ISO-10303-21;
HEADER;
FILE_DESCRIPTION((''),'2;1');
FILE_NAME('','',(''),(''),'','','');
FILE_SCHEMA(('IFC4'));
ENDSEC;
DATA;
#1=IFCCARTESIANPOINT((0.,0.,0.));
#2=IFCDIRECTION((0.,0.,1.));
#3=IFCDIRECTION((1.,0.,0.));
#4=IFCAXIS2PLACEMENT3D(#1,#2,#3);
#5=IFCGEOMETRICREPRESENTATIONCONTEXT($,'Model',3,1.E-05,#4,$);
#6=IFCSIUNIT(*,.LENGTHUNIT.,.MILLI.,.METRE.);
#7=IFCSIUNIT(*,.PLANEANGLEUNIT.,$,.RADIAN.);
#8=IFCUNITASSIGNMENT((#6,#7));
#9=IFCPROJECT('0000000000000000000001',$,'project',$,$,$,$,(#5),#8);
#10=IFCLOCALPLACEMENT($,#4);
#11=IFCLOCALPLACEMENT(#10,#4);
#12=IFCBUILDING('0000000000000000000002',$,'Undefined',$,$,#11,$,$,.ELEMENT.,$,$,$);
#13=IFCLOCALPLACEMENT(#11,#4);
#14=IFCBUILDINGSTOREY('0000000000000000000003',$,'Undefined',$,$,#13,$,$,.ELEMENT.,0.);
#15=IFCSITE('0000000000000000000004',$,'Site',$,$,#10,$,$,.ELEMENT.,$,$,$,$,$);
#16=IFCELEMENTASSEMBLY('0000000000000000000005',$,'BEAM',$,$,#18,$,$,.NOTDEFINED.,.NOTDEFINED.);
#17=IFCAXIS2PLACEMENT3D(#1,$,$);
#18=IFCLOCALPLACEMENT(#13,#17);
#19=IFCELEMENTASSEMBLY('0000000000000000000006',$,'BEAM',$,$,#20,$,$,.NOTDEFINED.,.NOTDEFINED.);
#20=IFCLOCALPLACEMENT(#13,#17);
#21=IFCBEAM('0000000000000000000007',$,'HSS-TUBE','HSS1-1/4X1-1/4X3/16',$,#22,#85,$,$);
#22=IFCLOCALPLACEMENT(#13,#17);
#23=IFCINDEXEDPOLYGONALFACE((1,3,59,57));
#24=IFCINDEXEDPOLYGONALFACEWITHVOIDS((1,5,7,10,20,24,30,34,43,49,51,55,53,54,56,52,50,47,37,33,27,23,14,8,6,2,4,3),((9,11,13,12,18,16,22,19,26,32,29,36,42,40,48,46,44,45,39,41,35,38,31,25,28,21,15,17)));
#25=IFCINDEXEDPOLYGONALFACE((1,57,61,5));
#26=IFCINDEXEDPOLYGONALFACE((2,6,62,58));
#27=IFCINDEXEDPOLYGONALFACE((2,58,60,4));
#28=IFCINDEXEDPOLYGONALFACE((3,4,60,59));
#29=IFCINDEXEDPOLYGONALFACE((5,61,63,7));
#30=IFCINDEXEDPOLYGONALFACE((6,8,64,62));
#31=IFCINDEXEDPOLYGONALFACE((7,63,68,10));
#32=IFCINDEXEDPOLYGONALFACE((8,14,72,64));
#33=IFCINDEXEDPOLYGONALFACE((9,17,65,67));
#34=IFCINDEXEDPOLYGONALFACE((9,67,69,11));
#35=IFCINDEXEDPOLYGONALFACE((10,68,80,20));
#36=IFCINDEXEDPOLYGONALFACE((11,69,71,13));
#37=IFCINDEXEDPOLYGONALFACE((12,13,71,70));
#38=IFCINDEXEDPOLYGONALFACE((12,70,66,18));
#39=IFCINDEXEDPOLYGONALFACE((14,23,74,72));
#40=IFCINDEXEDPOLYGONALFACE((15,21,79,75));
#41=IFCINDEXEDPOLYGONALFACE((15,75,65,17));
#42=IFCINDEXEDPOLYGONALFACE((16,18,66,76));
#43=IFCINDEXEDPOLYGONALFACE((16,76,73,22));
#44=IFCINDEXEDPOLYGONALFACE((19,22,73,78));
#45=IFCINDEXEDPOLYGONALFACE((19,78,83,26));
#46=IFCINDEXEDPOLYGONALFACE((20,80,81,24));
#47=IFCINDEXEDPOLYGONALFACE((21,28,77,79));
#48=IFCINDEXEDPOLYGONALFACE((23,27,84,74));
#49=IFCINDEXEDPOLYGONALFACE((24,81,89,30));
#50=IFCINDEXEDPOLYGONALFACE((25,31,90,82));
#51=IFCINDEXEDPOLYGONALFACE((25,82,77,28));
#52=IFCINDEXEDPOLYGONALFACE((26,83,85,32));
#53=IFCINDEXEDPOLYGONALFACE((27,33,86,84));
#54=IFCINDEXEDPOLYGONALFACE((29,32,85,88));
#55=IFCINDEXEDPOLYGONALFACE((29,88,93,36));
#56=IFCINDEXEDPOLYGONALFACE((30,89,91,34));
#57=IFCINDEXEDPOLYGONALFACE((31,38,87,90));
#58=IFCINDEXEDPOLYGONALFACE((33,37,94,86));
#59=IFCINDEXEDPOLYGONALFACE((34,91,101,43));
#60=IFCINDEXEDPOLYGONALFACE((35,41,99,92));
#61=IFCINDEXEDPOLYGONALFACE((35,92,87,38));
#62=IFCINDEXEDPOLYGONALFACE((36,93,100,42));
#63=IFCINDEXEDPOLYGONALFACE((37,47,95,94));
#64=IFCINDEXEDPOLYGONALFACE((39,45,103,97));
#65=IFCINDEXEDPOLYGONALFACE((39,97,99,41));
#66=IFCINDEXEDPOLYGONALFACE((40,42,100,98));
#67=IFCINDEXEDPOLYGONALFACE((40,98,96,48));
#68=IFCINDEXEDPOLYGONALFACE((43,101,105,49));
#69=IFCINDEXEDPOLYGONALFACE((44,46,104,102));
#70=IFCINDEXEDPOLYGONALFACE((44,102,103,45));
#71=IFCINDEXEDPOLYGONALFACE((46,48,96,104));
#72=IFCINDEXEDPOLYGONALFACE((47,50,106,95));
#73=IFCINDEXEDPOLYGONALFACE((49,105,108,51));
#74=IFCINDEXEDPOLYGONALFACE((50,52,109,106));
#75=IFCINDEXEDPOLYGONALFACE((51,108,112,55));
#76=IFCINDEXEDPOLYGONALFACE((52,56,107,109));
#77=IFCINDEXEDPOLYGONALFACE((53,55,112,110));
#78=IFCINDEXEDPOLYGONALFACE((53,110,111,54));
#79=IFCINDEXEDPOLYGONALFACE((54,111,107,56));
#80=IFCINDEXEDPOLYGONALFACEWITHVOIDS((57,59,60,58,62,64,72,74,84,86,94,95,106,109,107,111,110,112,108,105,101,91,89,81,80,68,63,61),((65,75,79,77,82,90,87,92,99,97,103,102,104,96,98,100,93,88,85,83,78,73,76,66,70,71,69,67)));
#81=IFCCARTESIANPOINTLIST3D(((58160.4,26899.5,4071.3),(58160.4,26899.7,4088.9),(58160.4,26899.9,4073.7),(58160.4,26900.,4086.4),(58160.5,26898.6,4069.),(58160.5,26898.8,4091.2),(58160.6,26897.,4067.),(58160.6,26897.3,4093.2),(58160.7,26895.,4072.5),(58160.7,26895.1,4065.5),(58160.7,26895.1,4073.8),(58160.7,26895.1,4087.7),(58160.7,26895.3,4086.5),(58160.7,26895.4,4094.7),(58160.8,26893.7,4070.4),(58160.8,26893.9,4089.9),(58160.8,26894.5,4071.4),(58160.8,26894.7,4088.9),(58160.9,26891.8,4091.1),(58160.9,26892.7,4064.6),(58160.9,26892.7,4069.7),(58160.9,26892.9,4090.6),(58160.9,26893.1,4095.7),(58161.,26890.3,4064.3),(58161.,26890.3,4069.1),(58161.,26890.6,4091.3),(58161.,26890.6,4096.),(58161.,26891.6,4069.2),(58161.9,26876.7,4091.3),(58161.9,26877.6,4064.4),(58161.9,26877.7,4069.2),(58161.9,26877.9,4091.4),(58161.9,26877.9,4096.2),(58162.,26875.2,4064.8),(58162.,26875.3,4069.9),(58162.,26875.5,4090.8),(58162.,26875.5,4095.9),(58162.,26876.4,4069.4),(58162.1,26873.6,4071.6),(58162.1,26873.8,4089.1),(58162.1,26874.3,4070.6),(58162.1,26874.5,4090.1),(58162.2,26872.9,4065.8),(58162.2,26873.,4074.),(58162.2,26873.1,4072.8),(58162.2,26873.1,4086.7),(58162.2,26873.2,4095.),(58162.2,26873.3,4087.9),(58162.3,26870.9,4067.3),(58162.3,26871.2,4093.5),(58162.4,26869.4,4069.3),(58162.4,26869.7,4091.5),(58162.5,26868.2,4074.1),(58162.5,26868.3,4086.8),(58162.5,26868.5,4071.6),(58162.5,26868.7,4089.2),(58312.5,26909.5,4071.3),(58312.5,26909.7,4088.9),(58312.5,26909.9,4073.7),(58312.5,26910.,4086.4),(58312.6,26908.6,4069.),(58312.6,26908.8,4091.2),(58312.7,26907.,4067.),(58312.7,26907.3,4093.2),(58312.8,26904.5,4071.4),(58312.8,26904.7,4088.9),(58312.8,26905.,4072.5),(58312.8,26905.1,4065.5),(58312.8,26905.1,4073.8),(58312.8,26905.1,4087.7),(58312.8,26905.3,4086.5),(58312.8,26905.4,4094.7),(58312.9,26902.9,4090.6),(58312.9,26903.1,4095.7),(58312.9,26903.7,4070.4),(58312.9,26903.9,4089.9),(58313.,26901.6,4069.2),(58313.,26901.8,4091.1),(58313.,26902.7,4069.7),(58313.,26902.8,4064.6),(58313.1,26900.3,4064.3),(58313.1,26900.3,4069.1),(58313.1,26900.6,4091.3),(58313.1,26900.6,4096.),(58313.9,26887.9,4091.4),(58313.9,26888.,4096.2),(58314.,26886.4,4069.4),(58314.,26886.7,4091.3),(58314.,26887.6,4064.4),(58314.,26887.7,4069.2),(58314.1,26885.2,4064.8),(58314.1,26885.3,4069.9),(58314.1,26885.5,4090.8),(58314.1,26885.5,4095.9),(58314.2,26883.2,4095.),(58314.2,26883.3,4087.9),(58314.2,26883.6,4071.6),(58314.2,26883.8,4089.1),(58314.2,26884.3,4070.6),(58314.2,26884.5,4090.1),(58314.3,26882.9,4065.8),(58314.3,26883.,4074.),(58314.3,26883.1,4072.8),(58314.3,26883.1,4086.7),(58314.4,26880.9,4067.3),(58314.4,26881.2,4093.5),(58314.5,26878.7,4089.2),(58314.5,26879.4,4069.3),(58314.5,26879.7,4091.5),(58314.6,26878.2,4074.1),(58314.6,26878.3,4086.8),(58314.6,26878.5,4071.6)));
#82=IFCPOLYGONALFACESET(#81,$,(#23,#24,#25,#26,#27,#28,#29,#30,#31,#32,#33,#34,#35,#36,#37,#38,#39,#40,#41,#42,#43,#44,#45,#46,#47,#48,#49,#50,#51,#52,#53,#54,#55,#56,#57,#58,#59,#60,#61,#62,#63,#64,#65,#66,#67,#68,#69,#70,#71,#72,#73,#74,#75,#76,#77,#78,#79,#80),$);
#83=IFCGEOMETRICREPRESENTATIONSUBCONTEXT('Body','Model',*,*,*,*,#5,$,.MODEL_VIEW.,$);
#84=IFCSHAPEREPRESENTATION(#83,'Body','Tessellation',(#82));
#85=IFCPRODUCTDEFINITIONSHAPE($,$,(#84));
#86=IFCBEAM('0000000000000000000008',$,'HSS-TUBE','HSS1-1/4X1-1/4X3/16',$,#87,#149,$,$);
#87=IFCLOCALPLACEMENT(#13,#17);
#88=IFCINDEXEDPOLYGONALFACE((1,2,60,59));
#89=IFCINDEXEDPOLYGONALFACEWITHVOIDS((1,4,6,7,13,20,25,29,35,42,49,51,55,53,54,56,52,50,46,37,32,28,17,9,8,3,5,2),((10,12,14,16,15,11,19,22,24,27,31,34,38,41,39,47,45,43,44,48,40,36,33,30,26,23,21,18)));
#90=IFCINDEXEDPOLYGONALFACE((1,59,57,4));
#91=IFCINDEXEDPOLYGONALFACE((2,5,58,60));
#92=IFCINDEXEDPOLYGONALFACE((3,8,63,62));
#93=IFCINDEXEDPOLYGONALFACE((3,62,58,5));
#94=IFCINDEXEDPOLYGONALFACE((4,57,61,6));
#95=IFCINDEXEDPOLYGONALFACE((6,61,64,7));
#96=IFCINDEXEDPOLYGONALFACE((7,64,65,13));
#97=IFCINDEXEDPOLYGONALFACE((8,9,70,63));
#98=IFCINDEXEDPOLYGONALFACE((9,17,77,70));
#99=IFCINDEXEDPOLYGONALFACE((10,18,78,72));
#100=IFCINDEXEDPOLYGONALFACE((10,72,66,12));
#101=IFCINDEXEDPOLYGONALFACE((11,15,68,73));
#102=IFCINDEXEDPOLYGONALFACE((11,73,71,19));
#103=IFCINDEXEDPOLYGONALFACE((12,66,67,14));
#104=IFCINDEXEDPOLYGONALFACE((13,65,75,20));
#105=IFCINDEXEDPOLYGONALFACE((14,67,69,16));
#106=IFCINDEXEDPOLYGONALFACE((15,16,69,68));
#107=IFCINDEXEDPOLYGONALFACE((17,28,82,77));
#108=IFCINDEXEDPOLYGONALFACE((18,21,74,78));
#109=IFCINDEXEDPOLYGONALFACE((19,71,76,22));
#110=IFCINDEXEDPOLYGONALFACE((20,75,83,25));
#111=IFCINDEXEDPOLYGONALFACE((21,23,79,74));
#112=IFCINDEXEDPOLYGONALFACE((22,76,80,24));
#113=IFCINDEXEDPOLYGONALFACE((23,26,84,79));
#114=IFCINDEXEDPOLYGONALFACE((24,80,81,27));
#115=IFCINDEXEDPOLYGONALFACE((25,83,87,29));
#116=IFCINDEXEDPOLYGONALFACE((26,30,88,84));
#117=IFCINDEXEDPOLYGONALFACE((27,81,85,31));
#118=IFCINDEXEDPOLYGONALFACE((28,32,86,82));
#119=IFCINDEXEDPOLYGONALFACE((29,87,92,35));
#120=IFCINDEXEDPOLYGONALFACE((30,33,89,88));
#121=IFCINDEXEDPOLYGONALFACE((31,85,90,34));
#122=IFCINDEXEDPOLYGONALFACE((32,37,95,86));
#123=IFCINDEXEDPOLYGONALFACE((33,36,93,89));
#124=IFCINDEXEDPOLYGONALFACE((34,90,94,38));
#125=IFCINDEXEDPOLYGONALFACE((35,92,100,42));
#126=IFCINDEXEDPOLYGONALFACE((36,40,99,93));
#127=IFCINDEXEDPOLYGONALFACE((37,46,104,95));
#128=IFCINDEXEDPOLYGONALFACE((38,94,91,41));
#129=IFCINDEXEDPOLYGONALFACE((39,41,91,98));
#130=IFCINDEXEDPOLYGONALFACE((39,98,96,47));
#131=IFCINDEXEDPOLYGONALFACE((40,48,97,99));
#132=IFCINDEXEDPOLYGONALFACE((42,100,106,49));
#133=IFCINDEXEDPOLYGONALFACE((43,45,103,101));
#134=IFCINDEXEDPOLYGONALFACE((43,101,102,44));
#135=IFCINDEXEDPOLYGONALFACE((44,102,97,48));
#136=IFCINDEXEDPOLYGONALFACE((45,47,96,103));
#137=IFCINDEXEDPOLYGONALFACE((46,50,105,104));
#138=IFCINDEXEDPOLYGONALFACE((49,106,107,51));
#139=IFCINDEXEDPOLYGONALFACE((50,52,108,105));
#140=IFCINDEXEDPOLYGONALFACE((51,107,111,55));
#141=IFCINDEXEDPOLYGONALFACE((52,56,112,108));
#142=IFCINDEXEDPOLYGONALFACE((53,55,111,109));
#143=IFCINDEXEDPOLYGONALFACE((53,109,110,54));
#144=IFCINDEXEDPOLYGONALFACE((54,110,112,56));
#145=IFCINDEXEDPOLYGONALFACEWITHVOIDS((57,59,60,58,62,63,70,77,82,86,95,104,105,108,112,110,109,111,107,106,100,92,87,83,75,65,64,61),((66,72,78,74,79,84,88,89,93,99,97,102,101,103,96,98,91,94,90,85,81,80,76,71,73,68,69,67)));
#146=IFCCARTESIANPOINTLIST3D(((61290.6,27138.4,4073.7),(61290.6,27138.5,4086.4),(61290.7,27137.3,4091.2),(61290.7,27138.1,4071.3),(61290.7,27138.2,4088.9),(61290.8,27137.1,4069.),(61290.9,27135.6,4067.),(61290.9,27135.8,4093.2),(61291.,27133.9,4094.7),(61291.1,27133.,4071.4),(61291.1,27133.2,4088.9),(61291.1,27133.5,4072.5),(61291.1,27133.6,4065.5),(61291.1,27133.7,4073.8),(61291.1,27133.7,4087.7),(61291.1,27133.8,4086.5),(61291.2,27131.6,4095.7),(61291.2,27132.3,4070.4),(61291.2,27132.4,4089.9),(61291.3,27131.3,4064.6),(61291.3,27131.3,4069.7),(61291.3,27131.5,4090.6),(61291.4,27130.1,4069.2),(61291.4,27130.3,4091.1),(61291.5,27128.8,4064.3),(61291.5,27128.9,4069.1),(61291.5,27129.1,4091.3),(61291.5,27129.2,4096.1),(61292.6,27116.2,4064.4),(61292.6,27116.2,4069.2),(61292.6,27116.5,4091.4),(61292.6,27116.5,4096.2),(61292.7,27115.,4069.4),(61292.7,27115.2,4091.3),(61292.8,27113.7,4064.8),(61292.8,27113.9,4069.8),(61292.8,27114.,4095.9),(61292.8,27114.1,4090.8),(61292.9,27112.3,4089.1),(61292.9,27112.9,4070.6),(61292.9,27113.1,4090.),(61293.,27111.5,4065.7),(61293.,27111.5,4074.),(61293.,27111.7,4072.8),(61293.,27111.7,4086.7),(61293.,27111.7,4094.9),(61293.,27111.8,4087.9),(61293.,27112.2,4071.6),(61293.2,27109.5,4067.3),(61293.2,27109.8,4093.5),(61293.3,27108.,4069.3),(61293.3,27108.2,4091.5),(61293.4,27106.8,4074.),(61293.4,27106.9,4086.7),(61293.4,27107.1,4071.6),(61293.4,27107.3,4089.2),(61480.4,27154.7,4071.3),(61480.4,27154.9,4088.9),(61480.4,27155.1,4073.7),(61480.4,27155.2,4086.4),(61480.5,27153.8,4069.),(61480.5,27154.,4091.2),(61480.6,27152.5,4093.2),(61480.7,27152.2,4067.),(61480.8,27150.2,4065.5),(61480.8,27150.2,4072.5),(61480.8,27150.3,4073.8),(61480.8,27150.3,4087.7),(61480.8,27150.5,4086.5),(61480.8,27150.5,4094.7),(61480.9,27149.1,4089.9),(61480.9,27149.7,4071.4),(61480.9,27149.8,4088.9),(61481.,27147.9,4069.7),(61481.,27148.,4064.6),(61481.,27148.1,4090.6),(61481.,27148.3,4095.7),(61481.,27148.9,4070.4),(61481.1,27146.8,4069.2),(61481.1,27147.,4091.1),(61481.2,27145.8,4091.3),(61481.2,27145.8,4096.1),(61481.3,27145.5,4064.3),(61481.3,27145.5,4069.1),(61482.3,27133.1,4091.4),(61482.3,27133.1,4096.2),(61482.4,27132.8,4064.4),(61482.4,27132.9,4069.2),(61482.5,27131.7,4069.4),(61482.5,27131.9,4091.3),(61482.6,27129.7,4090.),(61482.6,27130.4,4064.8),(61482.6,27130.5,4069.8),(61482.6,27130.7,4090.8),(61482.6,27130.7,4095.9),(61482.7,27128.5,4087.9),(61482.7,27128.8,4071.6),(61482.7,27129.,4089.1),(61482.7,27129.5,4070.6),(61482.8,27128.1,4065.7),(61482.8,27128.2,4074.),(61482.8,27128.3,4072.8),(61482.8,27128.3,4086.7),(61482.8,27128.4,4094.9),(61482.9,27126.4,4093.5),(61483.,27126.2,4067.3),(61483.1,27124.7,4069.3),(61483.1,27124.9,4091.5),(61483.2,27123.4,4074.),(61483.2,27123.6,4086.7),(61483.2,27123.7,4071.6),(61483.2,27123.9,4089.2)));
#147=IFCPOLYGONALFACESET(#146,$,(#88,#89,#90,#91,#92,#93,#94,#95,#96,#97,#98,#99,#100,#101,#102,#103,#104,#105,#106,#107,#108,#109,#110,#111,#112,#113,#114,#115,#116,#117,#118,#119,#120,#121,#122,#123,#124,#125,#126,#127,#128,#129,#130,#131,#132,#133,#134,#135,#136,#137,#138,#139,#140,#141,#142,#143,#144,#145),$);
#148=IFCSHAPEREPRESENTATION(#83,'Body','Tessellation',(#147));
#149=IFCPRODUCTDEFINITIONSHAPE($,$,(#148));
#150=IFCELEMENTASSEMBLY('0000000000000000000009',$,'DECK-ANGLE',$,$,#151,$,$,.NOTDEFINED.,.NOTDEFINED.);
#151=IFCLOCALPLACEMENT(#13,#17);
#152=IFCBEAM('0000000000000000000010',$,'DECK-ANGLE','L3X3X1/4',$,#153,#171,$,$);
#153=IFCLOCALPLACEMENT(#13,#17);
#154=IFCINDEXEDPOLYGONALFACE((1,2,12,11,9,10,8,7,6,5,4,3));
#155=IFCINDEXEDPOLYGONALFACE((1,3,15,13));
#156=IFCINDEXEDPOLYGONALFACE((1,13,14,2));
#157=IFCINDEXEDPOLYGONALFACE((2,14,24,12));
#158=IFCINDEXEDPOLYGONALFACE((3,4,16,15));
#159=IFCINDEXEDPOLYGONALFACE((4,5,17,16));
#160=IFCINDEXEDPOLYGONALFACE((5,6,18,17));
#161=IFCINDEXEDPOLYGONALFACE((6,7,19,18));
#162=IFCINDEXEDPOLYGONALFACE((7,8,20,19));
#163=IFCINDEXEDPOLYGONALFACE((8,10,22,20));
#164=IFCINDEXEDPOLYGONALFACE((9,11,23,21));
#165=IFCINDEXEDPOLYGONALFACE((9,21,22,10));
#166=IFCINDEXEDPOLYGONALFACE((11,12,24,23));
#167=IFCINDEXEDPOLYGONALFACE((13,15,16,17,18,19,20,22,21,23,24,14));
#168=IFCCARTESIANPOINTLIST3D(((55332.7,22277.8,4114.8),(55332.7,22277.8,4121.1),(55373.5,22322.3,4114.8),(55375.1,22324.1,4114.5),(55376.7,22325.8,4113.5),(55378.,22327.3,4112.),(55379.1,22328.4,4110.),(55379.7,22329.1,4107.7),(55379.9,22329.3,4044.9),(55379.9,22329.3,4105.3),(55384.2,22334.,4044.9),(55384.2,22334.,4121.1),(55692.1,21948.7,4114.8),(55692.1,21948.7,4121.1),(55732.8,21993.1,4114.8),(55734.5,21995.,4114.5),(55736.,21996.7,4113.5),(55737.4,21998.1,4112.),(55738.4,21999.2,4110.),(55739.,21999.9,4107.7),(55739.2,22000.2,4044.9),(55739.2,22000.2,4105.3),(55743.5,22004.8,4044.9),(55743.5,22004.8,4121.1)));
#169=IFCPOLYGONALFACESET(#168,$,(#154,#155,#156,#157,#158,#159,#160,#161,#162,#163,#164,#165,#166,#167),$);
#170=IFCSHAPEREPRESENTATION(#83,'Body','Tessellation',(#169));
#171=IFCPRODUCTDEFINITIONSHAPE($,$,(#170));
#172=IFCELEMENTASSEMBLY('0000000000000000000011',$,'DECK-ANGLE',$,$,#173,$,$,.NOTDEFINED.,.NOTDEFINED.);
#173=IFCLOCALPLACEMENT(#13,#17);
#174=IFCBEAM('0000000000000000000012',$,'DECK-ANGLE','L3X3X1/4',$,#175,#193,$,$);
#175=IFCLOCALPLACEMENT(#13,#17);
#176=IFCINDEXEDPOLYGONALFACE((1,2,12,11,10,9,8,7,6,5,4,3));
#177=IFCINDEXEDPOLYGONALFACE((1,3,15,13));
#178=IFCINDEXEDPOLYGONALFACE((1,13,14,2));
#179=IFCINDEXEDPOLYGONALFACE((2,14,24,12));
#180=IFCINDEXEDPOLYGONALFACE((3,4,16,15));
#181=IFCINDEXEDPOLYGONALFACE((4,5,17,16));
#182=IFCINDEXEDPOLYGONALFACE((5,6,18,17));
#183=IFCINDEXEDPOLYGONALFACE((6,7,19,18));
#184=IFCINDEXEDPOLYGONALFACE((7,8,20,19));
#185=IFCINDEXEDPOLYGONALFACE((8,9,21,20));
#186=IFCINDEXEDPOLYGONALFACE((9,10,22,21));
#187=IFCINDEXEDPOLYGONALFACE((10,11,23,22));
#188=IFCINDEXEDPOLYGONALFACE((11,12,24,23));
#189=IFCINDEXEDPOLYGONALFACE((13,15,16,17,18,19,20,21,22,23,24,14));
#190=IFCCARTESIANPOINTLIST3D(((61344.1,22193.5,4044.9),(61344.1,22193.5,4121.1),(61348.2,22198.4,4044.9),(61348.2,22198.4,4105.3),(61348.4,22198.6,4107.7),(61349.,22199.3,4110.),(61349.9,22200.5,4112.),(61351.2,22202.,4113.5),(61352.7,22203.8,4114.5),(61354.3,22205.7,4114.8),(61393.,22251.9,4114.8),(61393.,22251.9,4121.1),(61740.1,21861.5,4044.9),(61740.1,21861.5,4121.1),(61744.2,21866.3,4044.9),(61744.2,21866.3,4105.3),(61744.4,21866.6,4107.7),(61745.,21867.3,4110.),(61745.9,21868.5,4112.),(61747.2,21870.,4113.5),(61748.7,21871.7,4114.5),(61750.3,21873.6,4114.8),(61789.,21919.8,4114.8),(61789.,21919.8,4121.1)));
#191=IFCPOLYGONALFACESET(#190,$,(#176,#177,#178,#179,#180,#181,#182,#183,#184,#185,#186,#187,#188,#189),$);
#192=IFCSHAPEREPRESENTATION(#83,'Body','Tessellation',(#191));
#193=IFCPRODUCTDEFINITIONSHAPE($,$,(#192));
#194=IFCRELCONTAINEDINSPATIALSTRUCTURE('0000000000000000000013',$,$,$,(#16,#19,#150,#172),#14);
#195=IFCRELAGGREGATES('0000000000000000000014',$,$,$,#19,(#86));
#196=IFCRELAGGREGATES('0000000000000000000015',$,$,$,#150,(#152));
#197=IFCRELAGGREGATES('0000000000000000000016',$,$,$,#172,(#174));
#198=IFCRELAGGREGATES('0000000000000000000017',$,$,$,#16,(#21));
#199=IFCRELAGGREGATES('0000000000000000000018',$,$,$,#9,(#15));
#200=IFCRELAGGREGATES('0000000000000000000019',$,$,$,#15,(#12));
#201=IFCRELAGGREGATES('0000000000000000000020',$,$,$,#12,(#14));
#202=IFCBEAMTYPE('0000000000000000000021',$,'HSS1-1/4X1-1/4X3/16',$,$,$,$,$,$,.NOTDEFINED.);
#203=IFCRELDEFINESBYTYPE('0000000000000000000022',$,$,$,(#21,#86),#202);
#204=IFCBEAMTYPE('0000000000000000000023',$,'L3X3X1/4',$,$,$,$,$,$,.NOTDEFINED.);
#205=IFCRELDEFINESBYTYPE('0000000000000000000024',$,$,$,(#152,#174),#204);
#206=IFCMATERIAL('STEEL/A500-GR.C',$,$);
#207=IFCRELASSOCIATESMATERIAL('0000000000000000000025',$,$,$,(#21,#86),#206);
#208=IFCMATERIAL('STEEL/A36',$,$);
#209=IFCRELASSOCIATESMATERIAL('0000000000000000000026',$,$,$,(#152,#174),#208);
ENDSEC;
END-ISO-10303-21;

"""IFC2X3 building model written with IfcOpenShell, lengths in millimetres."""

from ifc_helpers import new_model, si_unit, frame, origin_with_axes, origin_2d_with_axis, place, context, subcontext, project, spatial, hollow_rectangle, l_section, extrude, material, type_object, element, aggregate, save


model = new_model("IFC2X3")

# Units and contexts
model_context = context("Model", 3, precision=1e-05, world=origin_with_axes())
body_context = subcontext(model_context, "Body", "Model", "MODEL_VIEW")
ifc_project = project(units=[si_unit("LENGTHUNIT", "METRE", prefix="MILLI"), si_unit("PLANEANGLEUNIT", "RADIAN")], contexts=[model_context])

# Site, building, storey
site_placement = place(None, origin_with_axes())
site = spatial("IfcSite", under=ifc_project, at=site_placement, Name="Site", CompositionType="ELEMENT")
building_placement = place(site_placement, origin_with_axes())
building = spatial("IfcBuilding", under=site, at=building_placement, Name="Undefined", CompositionType="ELEMENT")
storey_placement = place(building_placement, origin_with_axes())
storey = spatial("IfcBuildingStorey", under=building, at=storey_placement, Name="Undefined", CompositionType="ELEMENT", Elevation=0.0)

# Element assemblies
assembly_1_placement = place(storey_placement, origin_with_axes())
assembly_1 = element("IfcElementAssembly", 1, at=assembly_1_placement, inside=storey, Name="BEAM", AssemblyPlace="NOTDEFINED", PredefinedType="NOTDEFINED")
assembly_2_placement = place(storey_placement, origin_with_axes())
assembly_2 = element("IfcElementAssembly", 2, at=assembly_2_placement, inside=storey, Name="BEAM", AssemblyPlace="NOTDEFINED", PredefinedType="NOTDEFINED")

# Beams
ifc_material_1 = material(Name="STEEL/A500-GR.C")
beam_type_1 = type_object("IfcBeamType", Name="HSS1-1/4X1-1/4X3/16", PredefinedType="NOTDEFINED")
beam_1_placement = place(assembly_1_placement, frame((58161.5, 26884.1, 4080.2), z_axis=(-0.00069, 0.010495, 0.999945), x_axis=(0.997843, 0.065644, 0.0)))
beam_1 = element("IfcBeam", 3, at=beam_1_placement, type_object=beam_type_1, material=ifc_material_1, Name="HSS-TUBE", Description="HSS1-1/4X1-1/4X3/16", context=body_context, shape_type="SweptSolid", body=[
    extrude(hollow_rectangle(XDim=31.8, YDim=31.8, WallThickness=4.8, InnerFilletRadius=4.8, OuterFilletRadius=9.5, at=origin_2d_with_axis()), frame((152.4, 0.0, 0.0), z_axis=(-1.0, 0.0, 0.0), x_axis=(0.0, -1.0, 0.0)), (0.0, 0.0, 1.0), 152.4),
])
beam_2_placement = place(assembly_2_placement, frame((61292.0, 27122.7, 4080.2), z_axis=(-0.000852, 0.009709, 0.999953), x_axis=(0.996174, 0.087396, 0.0)))
beam_2 = element("IfcBeam", 4, at=beam_2_placement, type_object=beam_type_1, material=ifc_material_1, Name="HSS-TUBE", Description="HSS1-1/4X1-1/4X3/16", context=body_context, shape_type="SweptSolid", body=[
    extrude(hollow_rectangle(XDim=31.8, YDim=31.8, WallThickness=4.8, InnerFilletRadius=4.8, OuterFilletRadius=9.5, at=origin_2d_with_axis()), frame((190.5, 0.0, 0.0), z_axis=(-1.0, 0.0, 0.0), x_axis=(0.0, -1.0, 0.0)), (0.0, 0.0, 1.0), 190.5),
])
aggregate(assembly_2, [beam_2])

# Element assemblies, beams
assembly_3_placement = place(storey_placement, origin_with_axes())
assembly_3 = element("IfcElementAssembly", 5, at=assembly_3_placement, inside=storey, Name="DECK-ANGLE", AssemblyPlace="NOTDEFINED", PredefinedType="NOTDEFINED")
ifc_material_2 = material(Name="STEEL/A36")
beam_type_2 = type_object("IfcBeamType", Name="L3X3X1/4", PredefinedType="NOTDEFINED")
beam_3_placement = place(assembly_3_placement, frame((55717.8, 21976.8, 4083.0), z_axis=(0.0, 0.0, -1.0), x_axis=(-0.737395, 0.675462, 0.0)))
beam_3 = element("IfcBeam", 6, at=beam_3_placement, type_object=beam_type_2, material=ifc_material_2, Name="DECK-ANGLE", Description="L3X3X1/4", context=body_context, shape_type="SweptSolid", body=[
    extrude(l_section(Depth=76.2, Width=76.2, Thickness=6.3, FilletRadius=9.5, at=origin_2d_with_axis()), frame((487.3, 0.0, 0.0), z_axis=(-1.0, 0.0, 0.0), x_axis=(0.0, -1.0, 0.0)), (0.0, 0.0, 1.0), 487.3),
])
aggregate(assembly_3, [beam_3])
assembly_4_placement = place(storey_placement, origin_with_axes())
assembly_4 = element("IfcElementAssembly", 7, at=assembly_4_placement, inside=storey, Name="DECK-ANGLE", AssemblyPlace="NOTDEFINED", PredefinedType="NOTDEFINED")
beam_4_placement = place(assembly_4_placement, frame((61368.6, 22222.7, 4083.0), z_axis=(0.0, 0.0, -1.0), x_axis=(0.766269, -0.64252, 0.0)))
beam_4 = element("IfcBeam", 8, at=beam_4_placement, type_object=beam_type_2, material=ifc_material_2, Name="DECK-ANGLE", Description="L3X3X1/4", context=body_context, shape_type="SweptSolid", body=[
    extrude(l_section(Depth=76.2, Width=76.2, Thickness=6.3, FilletRadius=9.5, at=origin_2d_with_axis()), frame((516.8, 0.0, 0.0), z_axis=(-1.0, 0.0, 0.0), x_axis=(0.0, -1.0, 0.0)), (0.0, 0.0, 1.0), 516.8),
])
aggregate(assembly_4, [beam_4])

aggregate(assembly_1, [beam_1])

save(model, "model.ifc")
